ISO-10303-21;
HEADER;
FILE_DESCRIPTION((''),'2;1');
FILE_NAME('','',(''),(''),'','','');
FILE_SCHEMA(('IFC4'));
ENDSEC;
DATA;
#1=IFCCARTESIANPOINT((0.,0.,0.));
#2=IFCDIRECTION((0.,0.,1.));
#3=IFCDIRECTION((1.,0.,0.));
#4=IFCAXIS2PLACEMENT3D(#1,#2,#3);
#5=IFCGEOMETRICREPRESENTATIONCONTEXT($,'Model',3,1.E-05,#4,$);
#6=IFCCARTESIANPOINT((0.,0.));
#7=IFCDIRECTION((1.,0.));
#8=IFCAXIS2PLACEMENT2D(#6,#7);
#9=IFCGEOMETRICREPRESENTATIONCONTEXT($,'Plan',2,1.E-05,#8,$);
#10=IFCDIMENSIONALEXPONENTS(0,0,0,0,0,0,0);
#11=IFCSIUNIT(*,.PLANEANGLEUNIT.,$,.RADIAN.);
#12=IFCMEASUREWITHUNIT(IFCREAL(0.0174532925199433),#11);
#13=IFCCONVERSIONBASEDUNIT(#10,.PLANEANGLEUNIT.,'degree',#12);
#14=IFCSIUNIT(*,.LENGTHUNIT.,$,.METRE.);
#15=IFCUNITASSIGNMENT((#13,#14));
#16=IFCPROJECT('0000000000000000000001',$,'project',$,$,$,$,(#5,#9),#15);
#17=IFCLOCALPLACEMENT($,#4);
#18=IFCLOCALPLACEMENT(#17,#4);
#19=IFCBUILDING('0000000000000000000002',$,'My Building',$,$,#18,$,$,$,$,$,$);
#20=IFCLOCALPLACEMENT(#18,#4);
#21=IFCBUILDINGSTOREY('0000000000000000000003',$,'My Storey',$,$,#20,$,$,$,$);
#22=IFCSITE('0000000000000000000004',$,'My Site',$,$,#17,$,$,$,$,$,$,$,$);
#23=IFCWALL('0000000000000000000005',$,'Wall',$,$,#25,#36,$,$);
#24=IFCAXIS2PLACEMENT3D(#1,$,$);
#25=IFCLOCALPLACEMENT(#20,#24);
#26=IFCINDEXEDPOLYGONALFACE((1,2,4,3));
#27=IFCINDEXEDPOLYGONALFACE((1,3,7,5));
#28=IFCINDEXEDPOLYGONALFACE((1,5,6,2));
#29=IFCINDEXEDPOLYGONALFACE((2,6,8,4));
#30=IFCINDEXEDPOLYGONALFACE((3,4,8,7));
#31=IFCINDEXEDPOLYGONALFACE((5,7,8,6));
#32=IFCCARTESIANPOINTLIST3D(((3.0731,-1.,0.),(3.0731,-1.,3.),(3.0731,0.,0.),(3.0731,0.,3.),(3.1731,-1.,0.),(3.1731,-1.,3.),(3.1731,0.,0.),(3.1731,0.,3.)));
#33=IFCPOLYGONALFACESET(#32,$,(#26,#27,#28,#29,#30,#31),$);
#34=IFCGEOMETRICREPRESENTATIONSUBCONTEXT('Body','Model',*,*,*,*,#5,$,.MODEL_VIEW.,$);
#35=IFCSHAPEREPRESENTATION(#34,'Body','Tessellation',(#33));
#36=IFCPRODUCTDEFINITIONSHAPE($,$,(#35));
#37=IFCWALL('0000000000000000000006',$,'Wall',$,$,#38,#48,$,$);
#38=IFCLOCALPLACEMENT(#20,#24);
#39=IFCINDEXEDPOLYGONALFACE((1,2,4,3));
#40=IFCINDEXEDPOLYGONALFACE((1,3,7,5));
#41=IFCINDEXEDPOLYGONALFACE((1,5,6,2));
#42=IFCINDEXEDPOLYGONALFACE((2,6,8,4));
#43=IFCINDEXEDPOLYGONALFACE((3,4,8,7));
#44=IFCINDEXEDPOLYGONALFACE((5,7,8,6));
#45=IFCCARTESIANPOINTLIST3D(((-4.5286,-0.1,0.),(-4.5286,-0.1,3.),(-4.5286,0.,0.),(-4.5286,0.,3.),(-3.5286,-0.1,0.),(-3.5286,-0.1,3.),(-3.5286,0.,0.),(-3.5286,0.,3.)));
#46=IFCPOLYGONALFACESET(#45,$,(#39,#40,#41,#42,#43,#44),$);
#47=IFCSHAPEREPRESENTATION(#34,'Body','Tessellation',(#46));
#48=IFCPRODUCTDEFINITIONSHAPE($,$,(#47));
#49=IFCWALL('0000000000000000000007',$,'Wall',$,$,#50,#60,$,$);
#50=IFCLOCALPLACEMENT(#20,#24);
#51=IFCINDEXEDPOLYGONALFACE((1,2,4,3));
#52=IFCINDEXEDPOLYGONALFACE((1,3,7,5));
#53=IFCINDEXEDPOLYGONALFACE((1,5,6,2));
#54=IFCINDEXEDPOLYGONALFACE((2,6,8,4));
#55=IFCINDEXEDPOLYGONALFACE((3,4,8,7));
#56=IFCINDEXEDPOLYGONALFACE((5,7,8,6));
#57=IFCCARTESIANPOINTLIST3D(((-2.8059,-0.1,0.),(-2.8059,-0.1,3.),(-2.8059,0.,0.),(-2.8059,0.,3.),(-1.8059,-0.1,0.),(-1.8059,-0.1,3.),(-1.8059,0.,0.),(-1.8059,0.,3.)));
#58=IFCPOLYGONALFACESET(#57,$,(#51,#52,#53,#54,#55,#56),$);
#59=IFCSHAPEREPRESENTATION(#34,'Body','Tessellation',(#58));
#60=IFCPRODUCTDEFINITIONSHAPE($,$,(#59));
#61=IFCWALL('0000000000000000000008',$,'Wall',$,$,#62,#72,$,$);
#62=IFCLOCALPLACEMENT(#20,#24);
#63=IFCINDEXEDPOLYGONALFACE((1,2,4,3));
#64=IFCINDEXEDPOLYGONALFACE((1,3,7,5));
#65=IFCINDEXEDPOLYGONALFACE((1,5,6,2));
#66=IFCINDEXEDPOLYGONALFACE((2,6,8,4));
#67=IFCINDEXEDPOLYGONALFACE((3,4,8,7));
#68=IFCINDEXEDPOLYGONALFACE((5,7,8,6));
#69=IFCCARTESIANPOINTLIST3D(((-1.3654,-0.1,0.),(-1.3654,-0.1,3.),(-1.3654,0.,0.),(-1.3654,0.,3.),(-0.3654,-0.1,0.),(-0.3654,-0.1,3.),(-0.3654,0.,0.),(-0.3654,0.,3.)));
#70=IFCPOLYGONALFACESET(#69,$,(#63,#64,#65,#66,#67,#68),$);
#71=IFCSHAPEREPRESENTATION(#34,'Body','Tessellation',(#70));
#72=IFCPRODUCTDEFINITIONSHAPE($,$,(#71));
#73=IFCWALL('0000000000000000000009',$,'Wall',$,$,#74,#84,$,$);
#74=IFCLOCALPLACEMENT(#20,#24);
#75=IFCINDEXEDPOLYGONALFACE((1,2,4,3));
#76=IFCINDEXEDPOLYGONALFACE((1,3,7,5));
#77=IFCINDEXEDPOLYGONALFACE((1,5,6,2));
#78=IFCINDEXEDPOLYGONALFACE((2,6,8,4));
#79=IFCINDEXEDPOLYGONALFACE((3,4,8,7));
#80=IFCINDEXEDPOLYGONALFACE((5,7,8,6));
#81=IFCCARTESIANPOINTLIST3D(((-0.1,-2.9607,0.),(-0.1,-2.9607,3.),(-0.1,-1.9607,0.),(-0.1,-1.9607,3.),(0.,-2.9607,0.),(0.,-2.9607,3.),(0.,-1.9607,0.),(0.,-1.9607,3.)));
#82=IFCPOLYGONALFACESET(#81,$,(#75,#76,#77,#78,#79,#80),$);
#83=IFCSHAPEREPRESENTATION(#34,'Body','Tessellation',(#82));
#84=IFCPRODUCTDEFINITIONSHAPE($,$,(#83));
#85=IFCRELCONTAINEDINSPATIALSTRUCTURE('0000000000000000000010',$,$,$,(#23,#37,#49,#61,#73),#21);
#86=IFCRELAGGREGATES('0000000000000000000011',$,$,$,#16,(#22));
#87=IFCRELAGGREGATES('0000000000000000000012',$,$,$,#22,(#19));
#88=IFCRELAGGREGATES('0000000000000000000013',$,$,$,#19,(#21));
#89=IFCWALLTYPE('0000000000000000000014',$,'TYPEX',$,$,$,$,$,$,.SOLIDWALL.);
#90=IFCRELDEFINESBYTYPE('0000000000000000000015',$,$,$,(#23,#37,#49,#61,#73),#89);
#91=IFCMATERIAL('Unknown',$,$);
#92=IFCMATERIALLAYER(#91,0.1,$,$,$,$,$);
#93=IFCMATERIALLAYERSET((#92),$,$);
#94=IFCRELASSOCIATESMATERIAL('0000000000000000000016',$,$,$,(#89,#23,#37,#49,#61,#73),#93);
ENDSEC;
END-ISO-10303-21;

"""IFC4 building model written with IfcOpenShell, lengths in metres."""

from ifc_helpers import new_model, entity, si_unit, converted_unit, frame, origin_with_axes, origin_2d_with_axis, place, context, subcontext, project, spatial, indexed_curve, outline, extrude, material, layer, layer_set, layer_usage, type_object, element, save


model = new_model("IFC4")

# Units and contexts
model_context = context("Model", 3, precision=1e-05, world=origin_with_axes())
plan_context = context("Plan", 2, precision=1e-05, world=origin_2d_with_axis())
body_context_1 = subcontext(model_context, "Body", "Model", "MODEL_VIEW")
ifc_project = project(units=[converted_unit("PLANEANGLEUNIT", "degree", entity("IfcReal", 0.0174532925199433), si_unit("PLANEANGLEUNIT", "RADIAN"), dimensions=[0, 0, 0, 0, 0, 0, 0]), si_unit("LENGTHUNIT", "METRE")], contexts=[model_context, plan_context])

# Site, building, storey
site_placement = place(None, origin_with_axes())
site = spatial("IfcSite", under=ifc_project, at=site_placement, Name="My Site")
building_placement = place(site_placement, origin_with_axes())
building = spatial("IfcBuilding", under=site, at=building_placement, Name="My Building")
storey_placement = place(building_placement, origin_with_axes())
storey = spatial("IfcBuildingStorey", under=building, at=storey_placement, Name="My Storey")

# Walls
ifc_material = material(Name="Unknown")
ifc_layer = layer(ifc_material, 0.1)
ifc_layer_set = layer_set([ifc_layer])
wall_type = type_object("IfcWallType", Name="TYPEX", PredefinedType="SOLIDWALL", material=ifc_layer_set)
ifc_layer_usage_1 = layer_usage(ifc_layer_set, "AXIS2", "POSITIVE", 0.0)
wall_1_placement = place(storey_placement, frame((3.0731, 0.0, 0.0), z_axis=(0.0, 0.0, 1.0), x_axis=(0.0, -1.0, 0.0)))
element("IfcWall", 1, at=wall_1_placement, inside=storey, type_object=wall_type, material=ifc_layer_usage_1, Name="Wall", context=body_context_1, shape_type="SweptSolid", body=[
    extrude(outline(indexed_curve([(0.0, 0.0), (0.0, 0.1), (1.0, 0.1), (1.0, 0.0), (0.0, 0.0)], self_intersect=False)), origin_with_axes(), (0.0, 0.0, 1.0), 3.0),
])
ifc_layer_usage_2 = layer_usage(ifc_layer_set, "AXIS2", "POSITIVE", 0.0)
wall_2_placement = place(storey_placement, frame((-3.5286, 0.0, 0.0), z_axis=(0.0, 0.0, 1.0), x_axis=(-1.0, 0.0, 0.0)))
element("IfcWall", 2, at=wall_2_placement, inside=storey, type_object=wall_type, material=ifc_layer_usage_2, Name="Wall", context=body_context_1, shape_type="SweptSolid", body=[
    extrude(outline(indexed_curve([(0.0, 0.0), (0.0, 0.1), (1.0, 0.1), (1.0, 0.0), (0.0, 0.0)], self_intersect=False)), origin_with_axes(), (0.0, 0.0, 1.0), 3.0),
])
ifc_layer_usage_3 = layer_usage(ifc_layer_set, "AXIS2", "POSITIVE", 0.0)
wall_3_placement = place(storey_placement, frame((-1.8059, 0.0, 0.0), z_axis=(0.0, 0.0, 1.0), x_axis=(-1.0, 0.0, 0.0)))
element("IfcWall", 3, at=wall_3_placement, inside=storey, type_object=wall_type, material=ifc_layer_usage_3, Name="Wall", context=body_context_1, shape_type="SweptSolid", body=[
    extrude(outline(indexed_curve([(0.0, 0.0), (0.0, 0.1), (1.0, 0.1), (1.0, 0.0), (0.0, 0.0)], self_intersect=False)), origin_with_axes(), (0.0, 0.0, 1.0), 3.0),
])
ifc_layer_usage_4 = layer_usage(ifc_layer_set, "AXIS2", "POSITIVE", 0.0)
wall_4_placement = place(storey_placement, frame((-0.3654, 0.0, 0.0), z_axis=(0.0, 0.0, 1.0), x_axis=(-1.0, 0.0, 0.0)))
element("IfcWall", 4, at=wall_4_placement, inside=storey, type_object=wall_type, material=ifc_layer_usage_4, Name="Wall", context=body_context_1, shape_type="SweptSolid", body=[
    extrude(outline(indexed_curve([(0.0, 0.0), (0.0, 0.1), (1.0, 0.1), (1.0, 0.0), (0.0, 0.0)], self_intersect=False)), origin_with_axes(), (0.0, 0.0, 1.0), 3.0),
])
ifc_layer_usage_5 = layer_usage(ifc_layer_set, "AXIS2", "POSITIVE", 0.0)
wall_5_placement = place(storey_placement, frame((0.0, -2.9607, 0.0), z_axis=(0.0, 0.0, 1.0), x_axis=(0.0, 1.0, 0.0)))
element("IfcWall", 5, at=wall_5_placement, inside=storey, type_object=wall_type, material=ifc_layer_usage_5, Name="Wall", context=body_context_1, shape_type="SweptSolid", body=[
    extrude(outline(indexed_curve([(0.0, 0.0), (0.0, 0.1), (1.0, 0.1), (1.0, 0.0), (0.0, 0.0)], self_intersect=False)), origin_with_axes(), (0.0, 0.0, 1.0), 3.0),
])

save(model, "model.ifc")
